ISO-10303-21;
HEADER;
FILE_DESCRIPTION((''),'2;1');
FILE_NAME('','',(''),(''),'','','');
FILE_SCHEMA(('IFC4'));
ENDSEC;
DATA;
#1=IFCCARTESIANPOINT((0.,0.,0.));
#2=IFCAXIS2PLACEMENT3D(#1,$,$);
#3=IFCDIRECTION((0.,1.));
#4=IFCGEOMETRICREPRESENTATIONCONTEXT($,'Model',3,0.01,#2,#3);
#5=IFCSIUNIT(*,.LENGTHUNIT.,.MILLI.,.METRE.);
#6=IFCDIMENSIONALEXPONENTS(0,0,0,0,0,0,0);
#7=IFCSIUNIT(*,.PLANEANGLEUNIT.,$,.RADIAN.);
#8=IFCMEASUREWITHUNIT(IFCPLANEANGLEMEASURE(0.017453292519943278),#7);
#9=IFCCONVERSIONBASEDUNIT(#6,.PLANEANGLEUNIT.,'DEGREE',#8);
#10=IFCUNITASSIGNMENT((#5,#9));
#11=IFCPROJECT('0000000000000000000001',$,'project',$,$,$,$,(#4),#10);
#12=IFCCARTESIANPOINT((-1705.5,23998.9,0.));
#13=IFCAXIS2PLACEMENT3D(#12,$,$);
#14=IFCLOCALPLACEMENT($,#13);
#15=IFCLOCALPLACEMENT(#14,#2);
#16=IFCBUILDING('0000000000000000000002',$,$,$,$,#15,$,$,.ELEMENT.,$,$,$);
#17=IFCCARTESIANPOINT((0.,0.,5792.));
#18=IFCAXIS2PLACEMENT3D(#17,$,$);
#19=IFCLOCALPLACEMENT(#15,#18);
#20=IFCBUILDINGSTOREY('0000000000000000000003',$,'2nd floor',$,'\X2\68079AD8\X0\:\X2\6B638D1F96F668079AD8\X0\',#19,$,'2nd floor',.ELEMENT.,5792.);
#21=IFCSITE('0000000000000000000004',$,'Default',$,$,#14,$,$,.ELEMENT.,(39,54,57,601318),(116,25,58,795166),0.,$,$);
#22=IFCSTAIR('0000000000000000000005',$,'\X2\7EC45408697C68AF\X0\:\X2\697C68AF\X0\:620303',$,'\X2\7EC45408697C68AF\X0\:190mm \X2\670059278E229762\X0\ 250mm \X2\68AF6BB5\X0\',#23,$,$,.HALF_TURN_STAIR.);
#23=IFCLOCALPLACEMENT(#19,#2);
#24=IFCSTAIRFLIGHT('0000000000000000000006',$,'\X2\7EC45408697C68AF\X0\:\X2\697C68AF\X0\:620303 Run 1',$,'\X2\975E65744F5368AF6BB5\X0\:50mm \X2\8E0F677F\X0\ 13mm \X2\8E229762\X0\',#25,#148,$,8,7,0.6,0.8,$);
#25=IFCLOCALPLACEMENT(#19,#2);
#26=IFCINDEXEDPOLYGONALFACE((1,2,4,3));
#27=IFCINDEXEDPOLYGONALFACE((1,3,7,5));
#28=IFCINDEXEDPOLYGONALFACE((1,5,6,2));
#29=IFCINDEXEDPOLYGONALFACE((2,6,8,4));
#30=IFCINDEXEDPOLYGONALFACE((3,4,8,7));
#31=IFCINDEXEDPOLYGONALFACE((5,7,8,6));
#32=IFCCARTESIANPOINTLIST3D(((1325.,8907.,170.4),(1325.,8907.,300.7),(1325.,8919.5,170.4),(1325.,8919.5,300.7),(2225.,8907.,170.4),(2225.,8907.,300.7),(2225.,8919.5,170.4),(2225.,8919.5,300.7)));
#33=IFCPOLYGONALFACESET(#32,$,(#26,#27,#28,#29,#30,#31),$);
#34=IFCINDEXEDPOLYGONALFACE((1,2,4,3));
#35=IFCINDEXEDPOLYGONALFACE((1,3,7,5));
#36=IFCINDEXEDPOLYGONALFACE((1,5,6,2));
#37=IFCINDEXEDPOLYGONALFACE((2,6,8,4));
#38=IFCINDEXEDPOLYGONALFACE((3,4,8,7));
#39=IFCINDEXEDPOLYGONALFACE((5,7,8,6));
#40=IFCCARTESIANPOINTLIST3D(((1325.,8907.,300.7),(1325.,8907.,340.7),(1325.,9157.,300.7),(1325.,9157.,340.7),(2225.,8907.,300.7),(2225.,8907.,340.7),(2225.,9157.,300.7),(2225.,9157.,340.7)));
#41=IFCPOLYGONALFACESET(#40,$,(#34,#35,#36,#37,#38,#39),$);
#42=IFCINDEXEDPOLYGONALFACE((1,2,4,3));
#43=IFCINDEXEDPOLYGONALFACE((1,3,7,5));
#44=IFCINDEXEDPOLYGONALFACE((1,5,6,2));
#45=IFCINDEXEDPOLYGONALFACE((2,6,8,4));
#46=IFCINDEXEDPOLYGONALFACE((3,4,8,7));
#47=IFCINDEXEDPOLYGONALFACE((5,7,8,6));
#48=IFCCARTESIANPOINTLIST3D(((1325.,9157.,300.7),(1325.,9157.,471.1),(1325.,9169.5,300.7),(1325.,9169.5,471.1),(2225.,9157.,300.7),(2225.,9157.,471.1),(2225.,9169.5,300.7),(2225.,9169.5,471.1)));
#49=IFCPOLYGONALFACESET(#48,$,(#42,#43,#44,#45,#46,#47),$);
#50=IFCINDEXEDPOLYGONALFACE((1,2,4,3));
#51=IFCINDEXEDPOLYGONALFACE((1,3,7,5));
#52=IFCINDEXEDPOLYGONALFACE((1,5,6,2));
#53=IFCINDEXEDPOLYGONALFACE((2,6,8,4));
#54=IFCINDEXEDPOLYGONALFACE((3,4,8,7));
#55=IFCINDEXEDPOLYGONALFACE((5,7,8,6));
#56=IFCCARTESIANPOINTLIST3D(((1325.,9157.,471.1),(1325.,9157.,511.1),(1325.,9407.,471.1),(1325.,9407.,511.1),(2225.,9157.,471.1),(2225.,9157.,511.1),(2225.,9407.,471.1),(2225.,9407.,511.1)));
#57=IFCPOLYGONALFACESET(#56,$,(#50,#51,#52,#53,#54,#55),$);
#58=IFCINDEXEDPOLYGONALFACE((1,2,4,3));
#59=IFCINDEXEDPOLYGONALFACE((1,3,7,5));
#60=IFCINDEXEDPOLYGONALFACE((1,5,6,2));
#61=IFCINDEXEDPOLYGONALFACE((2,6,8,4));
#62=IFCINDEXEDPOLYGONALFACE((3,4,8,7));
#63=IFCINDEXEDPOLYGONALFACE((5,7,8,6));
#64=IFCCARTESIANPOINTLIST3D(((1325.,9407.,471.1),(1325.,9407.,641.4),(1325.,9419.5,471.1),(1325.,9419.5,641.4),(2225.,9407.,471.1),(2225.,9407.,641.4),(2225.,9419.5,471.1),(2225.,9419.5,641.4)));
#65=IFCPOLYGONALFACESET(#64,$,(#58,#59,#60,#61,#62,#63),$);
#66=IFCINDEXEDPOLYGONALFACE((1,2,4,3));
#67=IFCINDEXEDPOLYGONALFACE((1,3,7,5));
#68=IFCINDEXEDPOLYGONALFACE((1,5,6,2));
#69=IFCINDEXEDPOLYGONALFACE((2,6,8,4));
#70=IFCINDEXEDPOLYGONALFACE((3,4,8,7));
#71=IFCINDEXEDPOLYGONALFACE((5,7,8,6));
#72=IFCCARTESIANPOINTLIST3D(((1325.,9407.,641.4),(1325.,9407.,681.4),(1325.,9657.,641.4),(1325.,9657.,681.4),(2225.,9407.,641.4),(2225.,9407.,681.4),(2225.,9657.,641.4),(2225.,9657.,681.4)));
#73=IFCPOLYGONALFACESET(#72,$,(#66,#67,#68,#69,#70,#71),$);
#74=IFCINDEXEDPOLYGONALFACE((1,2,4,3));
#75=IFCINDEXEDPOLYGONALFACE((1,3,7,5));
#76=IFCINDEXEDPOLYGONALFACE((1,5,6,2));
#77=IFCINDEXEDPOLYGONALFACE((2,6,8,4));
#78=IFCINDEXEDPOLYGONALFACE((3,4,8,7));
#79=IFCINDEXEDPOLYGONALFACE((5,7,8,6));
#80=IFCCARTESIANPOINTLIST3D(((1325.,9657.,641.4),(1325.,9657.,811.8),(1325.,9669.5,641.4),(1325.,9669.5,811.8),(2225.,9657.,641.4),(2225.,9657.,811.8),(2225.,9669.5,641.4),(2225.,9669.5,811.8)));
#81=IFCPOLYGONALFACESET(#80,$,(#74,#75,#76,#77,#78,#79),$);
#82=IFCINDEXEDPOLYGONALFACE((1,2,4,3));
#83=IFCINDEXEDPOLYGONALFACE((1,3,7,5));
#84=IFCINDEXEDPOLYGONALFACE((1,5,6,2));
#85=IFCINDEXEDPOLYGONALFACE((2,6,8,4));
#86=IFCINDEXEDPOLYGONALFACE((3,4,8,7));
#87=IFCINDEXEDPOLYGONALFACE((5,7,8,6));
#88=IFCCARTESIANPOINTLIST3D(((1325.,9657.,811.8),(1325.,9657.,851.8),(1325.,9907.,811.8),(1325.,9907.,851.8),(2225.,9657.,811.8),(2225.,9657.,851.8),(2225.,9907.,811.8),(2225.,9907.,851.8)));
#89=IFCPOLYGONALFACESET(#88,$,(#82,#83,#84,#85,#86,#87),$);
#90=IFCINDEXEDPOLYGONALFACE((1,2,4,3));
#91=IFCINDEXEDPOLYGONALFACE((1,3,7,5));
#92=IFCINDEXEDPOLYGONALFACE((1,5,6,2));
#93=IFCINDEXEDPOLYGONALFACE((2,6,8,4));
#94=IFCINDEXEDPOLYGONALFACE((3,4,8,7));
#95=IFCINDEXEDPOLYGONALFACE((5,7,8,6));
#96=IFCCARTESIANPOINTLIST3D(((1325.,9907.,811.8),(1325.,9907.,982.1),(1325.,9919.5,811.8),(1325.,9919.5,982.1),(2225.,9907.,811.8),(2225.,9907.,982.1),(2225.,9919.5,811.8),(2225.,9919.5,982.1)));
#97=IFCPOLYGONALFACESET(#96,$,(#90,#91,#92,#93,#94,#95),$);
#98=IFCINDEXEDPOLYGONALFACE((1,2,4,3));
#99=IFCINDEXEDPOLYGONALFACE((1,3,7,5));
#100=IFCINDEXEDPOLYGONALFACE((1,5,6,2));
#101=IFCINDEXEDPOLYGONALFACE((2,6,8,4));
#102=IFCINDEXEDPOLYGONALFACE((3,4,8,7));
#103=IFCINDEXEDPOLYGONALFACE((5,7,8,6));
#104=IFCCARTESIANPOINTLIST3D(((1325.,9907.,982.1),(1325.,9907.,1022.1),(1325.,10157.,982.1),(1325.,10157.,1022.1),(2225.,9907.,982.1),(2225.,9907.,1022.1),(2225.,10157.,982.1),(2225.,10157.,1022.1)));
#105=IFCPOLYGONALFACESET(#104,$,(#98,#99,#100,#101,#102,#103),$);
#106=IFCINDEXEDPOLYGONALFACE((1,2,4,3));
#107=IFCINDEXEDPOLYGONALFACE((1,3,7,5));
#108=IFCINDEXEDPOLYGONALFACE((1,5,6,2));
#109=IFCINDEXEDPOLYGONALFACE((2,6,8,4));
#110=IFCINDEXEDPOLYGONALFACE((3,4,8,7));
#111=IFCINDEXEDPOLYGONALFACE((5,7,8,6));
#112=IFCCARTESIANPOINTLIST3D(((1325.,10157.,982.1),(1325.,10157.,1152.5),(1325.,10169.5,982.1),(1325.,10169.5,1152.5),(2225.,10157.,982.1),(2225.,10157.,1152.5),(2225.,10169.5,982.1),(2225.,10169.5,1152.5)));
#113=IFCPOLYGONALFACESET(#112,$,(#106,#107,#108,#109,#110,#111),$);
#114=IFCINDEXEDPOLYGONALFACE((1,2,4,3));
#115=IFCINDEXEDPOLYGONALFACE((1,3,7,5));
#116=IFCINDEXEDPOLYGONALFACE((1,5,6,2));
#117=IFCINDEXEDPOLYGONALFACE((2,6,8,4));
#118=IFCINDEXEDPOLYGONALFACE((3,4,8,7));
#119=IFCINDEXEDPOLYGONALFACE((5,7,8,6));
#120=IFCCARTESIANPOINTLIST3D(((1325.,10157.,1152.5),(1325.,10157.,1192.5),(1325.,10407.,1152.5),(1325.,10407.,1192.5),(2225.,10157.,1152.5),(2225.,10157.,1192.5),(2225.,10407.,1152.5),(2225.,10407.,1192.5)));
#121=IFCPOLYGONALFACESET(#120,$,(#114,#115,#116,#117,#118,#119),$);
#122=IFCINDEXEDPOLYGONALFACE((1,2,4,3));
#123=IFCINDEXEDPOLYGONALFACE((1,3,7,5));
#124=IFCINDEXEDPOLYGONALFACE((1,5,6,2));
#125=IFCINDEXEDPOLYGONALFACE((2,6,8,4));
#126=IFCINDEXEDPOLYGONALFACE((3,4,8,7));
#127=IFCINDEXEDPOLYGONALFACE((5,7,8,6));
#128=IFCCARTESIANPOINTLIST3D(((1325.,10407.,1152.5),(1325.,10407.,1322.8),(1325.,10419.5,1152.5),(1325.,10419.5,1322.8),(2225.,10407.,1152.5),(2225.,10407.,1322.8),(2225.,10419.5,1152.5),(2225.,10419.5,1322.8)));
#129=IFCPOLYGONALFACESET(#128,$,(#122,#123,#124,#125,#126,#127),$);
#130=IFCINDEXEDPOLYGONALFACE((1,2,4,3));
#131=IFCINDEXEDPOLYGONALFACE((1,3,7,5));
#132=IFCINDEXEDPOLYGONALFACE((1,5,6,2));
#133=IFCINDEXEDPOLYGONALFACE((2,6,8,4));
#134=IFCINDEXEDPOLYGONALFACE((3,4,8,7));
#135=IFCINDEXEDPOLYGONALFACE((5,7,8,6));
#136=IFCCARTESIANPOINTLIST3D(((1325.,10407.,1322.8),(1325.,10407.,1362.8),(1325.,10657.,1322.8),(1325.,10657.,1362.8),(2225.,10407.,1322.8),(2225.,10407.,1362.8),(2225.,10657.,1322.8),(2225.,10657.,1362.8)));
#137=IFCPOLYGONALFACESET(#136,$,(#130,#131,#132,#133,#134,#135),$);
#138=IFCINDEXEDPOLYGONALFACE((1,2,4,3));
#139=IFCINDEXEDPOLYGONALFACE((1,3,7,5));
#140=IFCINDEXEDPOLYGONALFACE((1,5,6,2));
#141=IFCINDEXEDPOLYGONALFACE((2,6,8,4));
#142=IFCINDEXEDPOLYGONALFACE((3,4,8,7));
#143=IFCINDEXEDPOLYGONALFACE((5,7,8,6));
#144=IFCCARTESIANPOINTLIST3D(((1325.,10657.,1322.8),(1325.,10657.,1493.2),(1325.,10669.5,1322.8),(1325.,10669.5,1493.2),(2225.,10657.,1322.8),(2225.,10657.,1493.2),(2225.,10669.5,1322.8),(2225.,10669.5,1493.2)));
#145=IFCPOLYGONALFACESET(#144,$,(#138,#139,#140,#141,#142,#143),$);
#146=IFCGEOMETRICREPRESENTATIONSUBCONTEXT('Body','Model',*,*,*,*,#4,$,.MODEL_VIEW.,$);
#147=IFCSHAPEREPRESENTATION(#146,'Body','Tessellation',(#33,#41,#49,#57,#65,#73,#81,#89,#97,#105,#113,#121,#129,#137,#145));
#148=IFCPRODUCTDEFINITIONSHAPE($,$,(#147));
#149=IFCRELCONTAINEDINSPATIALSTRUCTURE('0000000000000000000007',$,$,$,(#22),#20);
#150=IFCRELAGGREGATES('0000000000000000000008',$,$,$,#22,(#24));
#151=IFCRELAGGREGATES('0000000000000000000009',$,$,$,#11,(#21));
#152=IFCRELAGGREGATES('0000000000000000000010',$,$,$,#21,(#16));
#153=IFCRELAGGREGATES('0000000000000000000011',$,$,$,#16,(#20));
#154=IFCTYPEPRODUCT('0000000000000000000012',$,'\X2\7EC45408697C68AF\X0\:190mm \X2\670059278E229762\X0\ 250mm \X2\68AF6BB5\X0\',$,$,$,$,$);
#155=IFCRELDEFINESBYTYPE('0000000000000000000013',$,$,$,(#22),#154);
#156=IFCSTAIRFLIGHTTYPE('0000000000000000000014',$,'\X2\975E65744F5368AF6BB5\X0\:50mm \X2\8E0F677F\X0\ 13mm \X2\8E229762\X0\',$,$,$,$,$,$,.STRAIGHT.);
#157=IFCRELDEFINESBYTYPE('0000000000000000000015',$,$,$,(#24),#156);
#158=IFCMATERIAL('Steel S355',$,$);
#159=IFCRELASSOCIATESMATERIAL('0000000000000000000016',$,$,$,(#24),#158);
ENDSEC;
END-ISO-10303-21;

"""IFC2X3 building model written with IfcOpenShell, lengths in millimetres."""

from ifc_helpers import new_model, entity, si_unit, converted_unit, direction, frame, frame_2d, origin, origin_2d_with_axis, place, context, subcontext, project, spatial, rectangle, extrude, material, type_object, element, aggregate, save


model = new_model("IFC2X3")

# Units and contexts
model_context = context("Model", 3, precision=0.01, world=origin(), true_north=direction((0.0, 1.0)))
body_context = subcontext(model_context, "Body", "Model", "MODEL_VIEW")
ifc_project = project(units=[si_unit("LENGTHUNIT", "METRE", prefix="MILLI"), converted_unit("PLANEANGLEUNIT", "DEGREE", entity("IfcPlaneAngleMeasure", 0.017453292519943278), si_unit("PLANEANGLEUNIT", "RADIAN"), dimensions=[0, 0, 0, 0, 0, 0, 0])], contexts=[model_context])

# Site, building, storey
site_placement = place(None, frame((-1705.5, 23998.9, 0.0)))
site = spatial("IfcSite", under=ifc_project, at=site_placement, Name="Default", CompositionType="ELEMENT", RefLatitude=(39, 54, 57, 601318), RefLongitude=(116, 25, 58, 795166), RefElevation=0.0)
building_placement = place(site_placement, origin())
building = spatial("IfcBuilding", under=site, at=building_placement, CompositionType="ELEMENT")
storey_placement = place(building_placement, frame((0.0, 0.0, 5792.0)))
storey = spatial("IfcBuildingStorey", under=building, at=storey_placement, Name="2nd floor", ObjectType="标高:正负零标高", LongName="2nd floor", CompositionType="ELEMENT", Elevation=5792.0)

# Stair
type_product = type_object("IfcTypeProduct", Name="组合楼梯:190mm 最大踢面 250mm 梯段")
stair_placement = place(storey_placement, origin())
stair = element("IfcStair", 1, at=stair_placement, inside=storey, type_object=type_product, Name="组合楼梯:楼梯:620303", ObjectType="组合楼梯:190mm 最大踢面 250mm 梯段", ShapeType="HALF_TURN_STAIR")
ifc_material_1 = material(Name="Steel S355")

# Stair flight
stair_flight_type = type_object("IfcStairFlightType", Name="非整体梯段:50mm 踏板 13mm 踢面", PredefinedType="STRAIGHT")
stair_flight_1_placement = place(stair_placement, origin())
stair_flight_1 = element("IfcStairFlight", 2, at=stair_flight_1_placement, type_object=stair_flight_type, material=ifc_material_1, Name="组合楼梯:楼梯:620303 Run 1", ObjectType="非整体梯段:50mm 踏板 13mm 踢面", NumberOfRiser=8, NumberOfTreads=7, RiserHeight=0.6, TreadLength=0.8, context=body_context, shape_type="SweptSolid", body=[
    extrude(rectangle(XDim=900.0, YDim=12.5, at=frame_2d((0.0, 0.0), x_axis=(1.0, 0.0))), frame((1775.0, 8913.2, 170.4), z_axis=(0.0, 0.0, 1.0), x_axis=(-1.0, 0.0, 0.0)), (0.0, 0.0, 1.0), 130.4),
    extrude(rectangle(XDim=250.0, YDim=900.0, at=frame_2d((0.0, 0.0), x_axis=(1.0, 0.0))), frame((1775.0, 9032.0, 300.7), z_axis=(0.0, 0.0, 1.0), x_axis=(0.0, -1.0, 0.0)), (0.0, 0.0, 1.0), 40.0),
    extrude(rectangle(XDim=900.0, YDim=12.5, at=frame_2d((0.0, 0.0), x_axis=(1.0, 0.0))), frame((1775.0, 9163.2, 300.7), z_axis=(0.0, 0.0, 1.0), x_axis=(-1.0, 0.0, 0.0)), (0.0, 0.0, 1.0), 170.4),
    extrude(rectangle(XDim=250.0, YDim=900.0, at=frame_2d((0.0, 0.0), x_axis=(1.0, 0.0))), frame((1775.0, 9282.0, 471.1), z_axis=(0.0, 0.0, 1.0), x_axis=(0.0, -1.0, 0.0)), (0.0, 0.0, 1.0), 40.0),
    extrude(rectangle(XDim=900.0, YDim=12.5, at=frame_2d((0.0, 0.0), x_axis=(1.0, 0.0))), frame((1775.0, 9413.2, 471.1), z_axis=(0.0, 0.0, 1.0), x_axis=(-1.0, 0.0, 0.0)), (0.0, 0.0, 1.0), 170.4),
    extrude(rectangle(XDim=250.0, YDim=900.0, at=frame_2d((0.0, 0.0), x_axis=(1.0, 0.0))), frame((1775.0, 9532.0, 641.4), z_axis=(0.0, 0.0, 1.0), x_axis=(0.0, -1.0, 0.0)), (0.0, 0.0, 1.0), 40.0),
    extrude(rectangle(XDim=900.0, YDim=12.5, at=frame_2d((0.0, 0.0), x_axis=(1.0, 0.0))), frame((1775.0, 9663.2, 641.4), z_axis=(0.0, 0.0, 1.0), x_axis=(-1.0, 0.0, 0.0)), (0.0, 0.0, 1.0), 170.4),
    extrude(rectangle(XDim=250.0, YDim=900.0, at=frame_2d((0.0, 0.0), x_axis=(1.0, 0.0))), frame((1775.0, 9782.0, 811.8), z_axis=(0.0, 0.0, 1.0), x_axis=(0.0, -1.0, 0.0)), (0.0, 0.0, 1.0), 40.0),
    extrude(rectangle(XDim=900.0, YDim=12.5, at=frame_2d((0.0, 0.0), x_axis=(1.0, 0.0))), frame((1775.0, 9913.2, 811.8), z_axis=(0.0, 0.0, 1.0), x_axis=(-1.0, 0.0, 0.0)), (0.0, 0.0, 1.0), 170.4),
    extrude(rectangle(XDim=250.0, YDim=900.0, at=frame_2d((0.0, 0.0), x_axis=(1.0, 0.0))), frame((1775.0, 10032.0, 982.1), z_axis=(0.0, 0.0, 1.0), x_axis=(0.0, -1.0, 0.0)), (0.0, 0.0, 1.0), 40.0),
    extrude(rectangle(XDim=900.0, YDim=12.5, at=frame_2d((0.0, 0.0), x_axis=(1.0, 0.0))), frame((1775.0, 10163.2, 982.1), z_axis=(0.0, 0.0, 1.0), x_axis=(-1.0, 0.0, 0.0)), (0.0, 0.0, 1.0), 170.4),
    extrude(rectangle(XDim=250.0, YDim=900.0, at=frame_2d((0.0, 0.0), x_axis=(1.0, 0.0))), frame((1775.0, 10282.0, 1152.5), z_axis=(0.0, 0.0, 1.0), x_axis=(0.0, -1.0, 0.0)), (0.0, 0.0, 1.0), 40.0),
    extrude(rectangle(XDim=900.0, YDim=12.5, at=origin_2d_with_axis()), frame((1775.0, 10413.2, 1152.5), z_axis=(0.0, 0.0, 1.0), x_axis=(-1.0, 0.0, 0.0)), (0.0, 0.0, 1.0), 170.4),
    extrude(rectangle(XDim=250.0, YDim=900.0, at=frame_2d((0.0, 0.0), x_axis=(1.0, 0.0))), frame((1775.0, 10532.0, 1322.8), z_axis=(0.0, 0.0, 1.0), x_axis=(0.0, -1.0, 0.0)), (0.0, 0.0, 1.0), 40.0),
    extrude(rectangle(XDim=900.0, YDim=12.5, at=origin_2d_with_axis()), frame((1775.0, 10663.2, 1322.8), z_axis=(0.0, 0.0, 1.0), x_axis=(-1.0, 0.0, 0.0)), (0.0, 0.0, 1.0), 170.4),
])
aggregate(stair, [stair_flight_1])

save(model, "model.ifc")
